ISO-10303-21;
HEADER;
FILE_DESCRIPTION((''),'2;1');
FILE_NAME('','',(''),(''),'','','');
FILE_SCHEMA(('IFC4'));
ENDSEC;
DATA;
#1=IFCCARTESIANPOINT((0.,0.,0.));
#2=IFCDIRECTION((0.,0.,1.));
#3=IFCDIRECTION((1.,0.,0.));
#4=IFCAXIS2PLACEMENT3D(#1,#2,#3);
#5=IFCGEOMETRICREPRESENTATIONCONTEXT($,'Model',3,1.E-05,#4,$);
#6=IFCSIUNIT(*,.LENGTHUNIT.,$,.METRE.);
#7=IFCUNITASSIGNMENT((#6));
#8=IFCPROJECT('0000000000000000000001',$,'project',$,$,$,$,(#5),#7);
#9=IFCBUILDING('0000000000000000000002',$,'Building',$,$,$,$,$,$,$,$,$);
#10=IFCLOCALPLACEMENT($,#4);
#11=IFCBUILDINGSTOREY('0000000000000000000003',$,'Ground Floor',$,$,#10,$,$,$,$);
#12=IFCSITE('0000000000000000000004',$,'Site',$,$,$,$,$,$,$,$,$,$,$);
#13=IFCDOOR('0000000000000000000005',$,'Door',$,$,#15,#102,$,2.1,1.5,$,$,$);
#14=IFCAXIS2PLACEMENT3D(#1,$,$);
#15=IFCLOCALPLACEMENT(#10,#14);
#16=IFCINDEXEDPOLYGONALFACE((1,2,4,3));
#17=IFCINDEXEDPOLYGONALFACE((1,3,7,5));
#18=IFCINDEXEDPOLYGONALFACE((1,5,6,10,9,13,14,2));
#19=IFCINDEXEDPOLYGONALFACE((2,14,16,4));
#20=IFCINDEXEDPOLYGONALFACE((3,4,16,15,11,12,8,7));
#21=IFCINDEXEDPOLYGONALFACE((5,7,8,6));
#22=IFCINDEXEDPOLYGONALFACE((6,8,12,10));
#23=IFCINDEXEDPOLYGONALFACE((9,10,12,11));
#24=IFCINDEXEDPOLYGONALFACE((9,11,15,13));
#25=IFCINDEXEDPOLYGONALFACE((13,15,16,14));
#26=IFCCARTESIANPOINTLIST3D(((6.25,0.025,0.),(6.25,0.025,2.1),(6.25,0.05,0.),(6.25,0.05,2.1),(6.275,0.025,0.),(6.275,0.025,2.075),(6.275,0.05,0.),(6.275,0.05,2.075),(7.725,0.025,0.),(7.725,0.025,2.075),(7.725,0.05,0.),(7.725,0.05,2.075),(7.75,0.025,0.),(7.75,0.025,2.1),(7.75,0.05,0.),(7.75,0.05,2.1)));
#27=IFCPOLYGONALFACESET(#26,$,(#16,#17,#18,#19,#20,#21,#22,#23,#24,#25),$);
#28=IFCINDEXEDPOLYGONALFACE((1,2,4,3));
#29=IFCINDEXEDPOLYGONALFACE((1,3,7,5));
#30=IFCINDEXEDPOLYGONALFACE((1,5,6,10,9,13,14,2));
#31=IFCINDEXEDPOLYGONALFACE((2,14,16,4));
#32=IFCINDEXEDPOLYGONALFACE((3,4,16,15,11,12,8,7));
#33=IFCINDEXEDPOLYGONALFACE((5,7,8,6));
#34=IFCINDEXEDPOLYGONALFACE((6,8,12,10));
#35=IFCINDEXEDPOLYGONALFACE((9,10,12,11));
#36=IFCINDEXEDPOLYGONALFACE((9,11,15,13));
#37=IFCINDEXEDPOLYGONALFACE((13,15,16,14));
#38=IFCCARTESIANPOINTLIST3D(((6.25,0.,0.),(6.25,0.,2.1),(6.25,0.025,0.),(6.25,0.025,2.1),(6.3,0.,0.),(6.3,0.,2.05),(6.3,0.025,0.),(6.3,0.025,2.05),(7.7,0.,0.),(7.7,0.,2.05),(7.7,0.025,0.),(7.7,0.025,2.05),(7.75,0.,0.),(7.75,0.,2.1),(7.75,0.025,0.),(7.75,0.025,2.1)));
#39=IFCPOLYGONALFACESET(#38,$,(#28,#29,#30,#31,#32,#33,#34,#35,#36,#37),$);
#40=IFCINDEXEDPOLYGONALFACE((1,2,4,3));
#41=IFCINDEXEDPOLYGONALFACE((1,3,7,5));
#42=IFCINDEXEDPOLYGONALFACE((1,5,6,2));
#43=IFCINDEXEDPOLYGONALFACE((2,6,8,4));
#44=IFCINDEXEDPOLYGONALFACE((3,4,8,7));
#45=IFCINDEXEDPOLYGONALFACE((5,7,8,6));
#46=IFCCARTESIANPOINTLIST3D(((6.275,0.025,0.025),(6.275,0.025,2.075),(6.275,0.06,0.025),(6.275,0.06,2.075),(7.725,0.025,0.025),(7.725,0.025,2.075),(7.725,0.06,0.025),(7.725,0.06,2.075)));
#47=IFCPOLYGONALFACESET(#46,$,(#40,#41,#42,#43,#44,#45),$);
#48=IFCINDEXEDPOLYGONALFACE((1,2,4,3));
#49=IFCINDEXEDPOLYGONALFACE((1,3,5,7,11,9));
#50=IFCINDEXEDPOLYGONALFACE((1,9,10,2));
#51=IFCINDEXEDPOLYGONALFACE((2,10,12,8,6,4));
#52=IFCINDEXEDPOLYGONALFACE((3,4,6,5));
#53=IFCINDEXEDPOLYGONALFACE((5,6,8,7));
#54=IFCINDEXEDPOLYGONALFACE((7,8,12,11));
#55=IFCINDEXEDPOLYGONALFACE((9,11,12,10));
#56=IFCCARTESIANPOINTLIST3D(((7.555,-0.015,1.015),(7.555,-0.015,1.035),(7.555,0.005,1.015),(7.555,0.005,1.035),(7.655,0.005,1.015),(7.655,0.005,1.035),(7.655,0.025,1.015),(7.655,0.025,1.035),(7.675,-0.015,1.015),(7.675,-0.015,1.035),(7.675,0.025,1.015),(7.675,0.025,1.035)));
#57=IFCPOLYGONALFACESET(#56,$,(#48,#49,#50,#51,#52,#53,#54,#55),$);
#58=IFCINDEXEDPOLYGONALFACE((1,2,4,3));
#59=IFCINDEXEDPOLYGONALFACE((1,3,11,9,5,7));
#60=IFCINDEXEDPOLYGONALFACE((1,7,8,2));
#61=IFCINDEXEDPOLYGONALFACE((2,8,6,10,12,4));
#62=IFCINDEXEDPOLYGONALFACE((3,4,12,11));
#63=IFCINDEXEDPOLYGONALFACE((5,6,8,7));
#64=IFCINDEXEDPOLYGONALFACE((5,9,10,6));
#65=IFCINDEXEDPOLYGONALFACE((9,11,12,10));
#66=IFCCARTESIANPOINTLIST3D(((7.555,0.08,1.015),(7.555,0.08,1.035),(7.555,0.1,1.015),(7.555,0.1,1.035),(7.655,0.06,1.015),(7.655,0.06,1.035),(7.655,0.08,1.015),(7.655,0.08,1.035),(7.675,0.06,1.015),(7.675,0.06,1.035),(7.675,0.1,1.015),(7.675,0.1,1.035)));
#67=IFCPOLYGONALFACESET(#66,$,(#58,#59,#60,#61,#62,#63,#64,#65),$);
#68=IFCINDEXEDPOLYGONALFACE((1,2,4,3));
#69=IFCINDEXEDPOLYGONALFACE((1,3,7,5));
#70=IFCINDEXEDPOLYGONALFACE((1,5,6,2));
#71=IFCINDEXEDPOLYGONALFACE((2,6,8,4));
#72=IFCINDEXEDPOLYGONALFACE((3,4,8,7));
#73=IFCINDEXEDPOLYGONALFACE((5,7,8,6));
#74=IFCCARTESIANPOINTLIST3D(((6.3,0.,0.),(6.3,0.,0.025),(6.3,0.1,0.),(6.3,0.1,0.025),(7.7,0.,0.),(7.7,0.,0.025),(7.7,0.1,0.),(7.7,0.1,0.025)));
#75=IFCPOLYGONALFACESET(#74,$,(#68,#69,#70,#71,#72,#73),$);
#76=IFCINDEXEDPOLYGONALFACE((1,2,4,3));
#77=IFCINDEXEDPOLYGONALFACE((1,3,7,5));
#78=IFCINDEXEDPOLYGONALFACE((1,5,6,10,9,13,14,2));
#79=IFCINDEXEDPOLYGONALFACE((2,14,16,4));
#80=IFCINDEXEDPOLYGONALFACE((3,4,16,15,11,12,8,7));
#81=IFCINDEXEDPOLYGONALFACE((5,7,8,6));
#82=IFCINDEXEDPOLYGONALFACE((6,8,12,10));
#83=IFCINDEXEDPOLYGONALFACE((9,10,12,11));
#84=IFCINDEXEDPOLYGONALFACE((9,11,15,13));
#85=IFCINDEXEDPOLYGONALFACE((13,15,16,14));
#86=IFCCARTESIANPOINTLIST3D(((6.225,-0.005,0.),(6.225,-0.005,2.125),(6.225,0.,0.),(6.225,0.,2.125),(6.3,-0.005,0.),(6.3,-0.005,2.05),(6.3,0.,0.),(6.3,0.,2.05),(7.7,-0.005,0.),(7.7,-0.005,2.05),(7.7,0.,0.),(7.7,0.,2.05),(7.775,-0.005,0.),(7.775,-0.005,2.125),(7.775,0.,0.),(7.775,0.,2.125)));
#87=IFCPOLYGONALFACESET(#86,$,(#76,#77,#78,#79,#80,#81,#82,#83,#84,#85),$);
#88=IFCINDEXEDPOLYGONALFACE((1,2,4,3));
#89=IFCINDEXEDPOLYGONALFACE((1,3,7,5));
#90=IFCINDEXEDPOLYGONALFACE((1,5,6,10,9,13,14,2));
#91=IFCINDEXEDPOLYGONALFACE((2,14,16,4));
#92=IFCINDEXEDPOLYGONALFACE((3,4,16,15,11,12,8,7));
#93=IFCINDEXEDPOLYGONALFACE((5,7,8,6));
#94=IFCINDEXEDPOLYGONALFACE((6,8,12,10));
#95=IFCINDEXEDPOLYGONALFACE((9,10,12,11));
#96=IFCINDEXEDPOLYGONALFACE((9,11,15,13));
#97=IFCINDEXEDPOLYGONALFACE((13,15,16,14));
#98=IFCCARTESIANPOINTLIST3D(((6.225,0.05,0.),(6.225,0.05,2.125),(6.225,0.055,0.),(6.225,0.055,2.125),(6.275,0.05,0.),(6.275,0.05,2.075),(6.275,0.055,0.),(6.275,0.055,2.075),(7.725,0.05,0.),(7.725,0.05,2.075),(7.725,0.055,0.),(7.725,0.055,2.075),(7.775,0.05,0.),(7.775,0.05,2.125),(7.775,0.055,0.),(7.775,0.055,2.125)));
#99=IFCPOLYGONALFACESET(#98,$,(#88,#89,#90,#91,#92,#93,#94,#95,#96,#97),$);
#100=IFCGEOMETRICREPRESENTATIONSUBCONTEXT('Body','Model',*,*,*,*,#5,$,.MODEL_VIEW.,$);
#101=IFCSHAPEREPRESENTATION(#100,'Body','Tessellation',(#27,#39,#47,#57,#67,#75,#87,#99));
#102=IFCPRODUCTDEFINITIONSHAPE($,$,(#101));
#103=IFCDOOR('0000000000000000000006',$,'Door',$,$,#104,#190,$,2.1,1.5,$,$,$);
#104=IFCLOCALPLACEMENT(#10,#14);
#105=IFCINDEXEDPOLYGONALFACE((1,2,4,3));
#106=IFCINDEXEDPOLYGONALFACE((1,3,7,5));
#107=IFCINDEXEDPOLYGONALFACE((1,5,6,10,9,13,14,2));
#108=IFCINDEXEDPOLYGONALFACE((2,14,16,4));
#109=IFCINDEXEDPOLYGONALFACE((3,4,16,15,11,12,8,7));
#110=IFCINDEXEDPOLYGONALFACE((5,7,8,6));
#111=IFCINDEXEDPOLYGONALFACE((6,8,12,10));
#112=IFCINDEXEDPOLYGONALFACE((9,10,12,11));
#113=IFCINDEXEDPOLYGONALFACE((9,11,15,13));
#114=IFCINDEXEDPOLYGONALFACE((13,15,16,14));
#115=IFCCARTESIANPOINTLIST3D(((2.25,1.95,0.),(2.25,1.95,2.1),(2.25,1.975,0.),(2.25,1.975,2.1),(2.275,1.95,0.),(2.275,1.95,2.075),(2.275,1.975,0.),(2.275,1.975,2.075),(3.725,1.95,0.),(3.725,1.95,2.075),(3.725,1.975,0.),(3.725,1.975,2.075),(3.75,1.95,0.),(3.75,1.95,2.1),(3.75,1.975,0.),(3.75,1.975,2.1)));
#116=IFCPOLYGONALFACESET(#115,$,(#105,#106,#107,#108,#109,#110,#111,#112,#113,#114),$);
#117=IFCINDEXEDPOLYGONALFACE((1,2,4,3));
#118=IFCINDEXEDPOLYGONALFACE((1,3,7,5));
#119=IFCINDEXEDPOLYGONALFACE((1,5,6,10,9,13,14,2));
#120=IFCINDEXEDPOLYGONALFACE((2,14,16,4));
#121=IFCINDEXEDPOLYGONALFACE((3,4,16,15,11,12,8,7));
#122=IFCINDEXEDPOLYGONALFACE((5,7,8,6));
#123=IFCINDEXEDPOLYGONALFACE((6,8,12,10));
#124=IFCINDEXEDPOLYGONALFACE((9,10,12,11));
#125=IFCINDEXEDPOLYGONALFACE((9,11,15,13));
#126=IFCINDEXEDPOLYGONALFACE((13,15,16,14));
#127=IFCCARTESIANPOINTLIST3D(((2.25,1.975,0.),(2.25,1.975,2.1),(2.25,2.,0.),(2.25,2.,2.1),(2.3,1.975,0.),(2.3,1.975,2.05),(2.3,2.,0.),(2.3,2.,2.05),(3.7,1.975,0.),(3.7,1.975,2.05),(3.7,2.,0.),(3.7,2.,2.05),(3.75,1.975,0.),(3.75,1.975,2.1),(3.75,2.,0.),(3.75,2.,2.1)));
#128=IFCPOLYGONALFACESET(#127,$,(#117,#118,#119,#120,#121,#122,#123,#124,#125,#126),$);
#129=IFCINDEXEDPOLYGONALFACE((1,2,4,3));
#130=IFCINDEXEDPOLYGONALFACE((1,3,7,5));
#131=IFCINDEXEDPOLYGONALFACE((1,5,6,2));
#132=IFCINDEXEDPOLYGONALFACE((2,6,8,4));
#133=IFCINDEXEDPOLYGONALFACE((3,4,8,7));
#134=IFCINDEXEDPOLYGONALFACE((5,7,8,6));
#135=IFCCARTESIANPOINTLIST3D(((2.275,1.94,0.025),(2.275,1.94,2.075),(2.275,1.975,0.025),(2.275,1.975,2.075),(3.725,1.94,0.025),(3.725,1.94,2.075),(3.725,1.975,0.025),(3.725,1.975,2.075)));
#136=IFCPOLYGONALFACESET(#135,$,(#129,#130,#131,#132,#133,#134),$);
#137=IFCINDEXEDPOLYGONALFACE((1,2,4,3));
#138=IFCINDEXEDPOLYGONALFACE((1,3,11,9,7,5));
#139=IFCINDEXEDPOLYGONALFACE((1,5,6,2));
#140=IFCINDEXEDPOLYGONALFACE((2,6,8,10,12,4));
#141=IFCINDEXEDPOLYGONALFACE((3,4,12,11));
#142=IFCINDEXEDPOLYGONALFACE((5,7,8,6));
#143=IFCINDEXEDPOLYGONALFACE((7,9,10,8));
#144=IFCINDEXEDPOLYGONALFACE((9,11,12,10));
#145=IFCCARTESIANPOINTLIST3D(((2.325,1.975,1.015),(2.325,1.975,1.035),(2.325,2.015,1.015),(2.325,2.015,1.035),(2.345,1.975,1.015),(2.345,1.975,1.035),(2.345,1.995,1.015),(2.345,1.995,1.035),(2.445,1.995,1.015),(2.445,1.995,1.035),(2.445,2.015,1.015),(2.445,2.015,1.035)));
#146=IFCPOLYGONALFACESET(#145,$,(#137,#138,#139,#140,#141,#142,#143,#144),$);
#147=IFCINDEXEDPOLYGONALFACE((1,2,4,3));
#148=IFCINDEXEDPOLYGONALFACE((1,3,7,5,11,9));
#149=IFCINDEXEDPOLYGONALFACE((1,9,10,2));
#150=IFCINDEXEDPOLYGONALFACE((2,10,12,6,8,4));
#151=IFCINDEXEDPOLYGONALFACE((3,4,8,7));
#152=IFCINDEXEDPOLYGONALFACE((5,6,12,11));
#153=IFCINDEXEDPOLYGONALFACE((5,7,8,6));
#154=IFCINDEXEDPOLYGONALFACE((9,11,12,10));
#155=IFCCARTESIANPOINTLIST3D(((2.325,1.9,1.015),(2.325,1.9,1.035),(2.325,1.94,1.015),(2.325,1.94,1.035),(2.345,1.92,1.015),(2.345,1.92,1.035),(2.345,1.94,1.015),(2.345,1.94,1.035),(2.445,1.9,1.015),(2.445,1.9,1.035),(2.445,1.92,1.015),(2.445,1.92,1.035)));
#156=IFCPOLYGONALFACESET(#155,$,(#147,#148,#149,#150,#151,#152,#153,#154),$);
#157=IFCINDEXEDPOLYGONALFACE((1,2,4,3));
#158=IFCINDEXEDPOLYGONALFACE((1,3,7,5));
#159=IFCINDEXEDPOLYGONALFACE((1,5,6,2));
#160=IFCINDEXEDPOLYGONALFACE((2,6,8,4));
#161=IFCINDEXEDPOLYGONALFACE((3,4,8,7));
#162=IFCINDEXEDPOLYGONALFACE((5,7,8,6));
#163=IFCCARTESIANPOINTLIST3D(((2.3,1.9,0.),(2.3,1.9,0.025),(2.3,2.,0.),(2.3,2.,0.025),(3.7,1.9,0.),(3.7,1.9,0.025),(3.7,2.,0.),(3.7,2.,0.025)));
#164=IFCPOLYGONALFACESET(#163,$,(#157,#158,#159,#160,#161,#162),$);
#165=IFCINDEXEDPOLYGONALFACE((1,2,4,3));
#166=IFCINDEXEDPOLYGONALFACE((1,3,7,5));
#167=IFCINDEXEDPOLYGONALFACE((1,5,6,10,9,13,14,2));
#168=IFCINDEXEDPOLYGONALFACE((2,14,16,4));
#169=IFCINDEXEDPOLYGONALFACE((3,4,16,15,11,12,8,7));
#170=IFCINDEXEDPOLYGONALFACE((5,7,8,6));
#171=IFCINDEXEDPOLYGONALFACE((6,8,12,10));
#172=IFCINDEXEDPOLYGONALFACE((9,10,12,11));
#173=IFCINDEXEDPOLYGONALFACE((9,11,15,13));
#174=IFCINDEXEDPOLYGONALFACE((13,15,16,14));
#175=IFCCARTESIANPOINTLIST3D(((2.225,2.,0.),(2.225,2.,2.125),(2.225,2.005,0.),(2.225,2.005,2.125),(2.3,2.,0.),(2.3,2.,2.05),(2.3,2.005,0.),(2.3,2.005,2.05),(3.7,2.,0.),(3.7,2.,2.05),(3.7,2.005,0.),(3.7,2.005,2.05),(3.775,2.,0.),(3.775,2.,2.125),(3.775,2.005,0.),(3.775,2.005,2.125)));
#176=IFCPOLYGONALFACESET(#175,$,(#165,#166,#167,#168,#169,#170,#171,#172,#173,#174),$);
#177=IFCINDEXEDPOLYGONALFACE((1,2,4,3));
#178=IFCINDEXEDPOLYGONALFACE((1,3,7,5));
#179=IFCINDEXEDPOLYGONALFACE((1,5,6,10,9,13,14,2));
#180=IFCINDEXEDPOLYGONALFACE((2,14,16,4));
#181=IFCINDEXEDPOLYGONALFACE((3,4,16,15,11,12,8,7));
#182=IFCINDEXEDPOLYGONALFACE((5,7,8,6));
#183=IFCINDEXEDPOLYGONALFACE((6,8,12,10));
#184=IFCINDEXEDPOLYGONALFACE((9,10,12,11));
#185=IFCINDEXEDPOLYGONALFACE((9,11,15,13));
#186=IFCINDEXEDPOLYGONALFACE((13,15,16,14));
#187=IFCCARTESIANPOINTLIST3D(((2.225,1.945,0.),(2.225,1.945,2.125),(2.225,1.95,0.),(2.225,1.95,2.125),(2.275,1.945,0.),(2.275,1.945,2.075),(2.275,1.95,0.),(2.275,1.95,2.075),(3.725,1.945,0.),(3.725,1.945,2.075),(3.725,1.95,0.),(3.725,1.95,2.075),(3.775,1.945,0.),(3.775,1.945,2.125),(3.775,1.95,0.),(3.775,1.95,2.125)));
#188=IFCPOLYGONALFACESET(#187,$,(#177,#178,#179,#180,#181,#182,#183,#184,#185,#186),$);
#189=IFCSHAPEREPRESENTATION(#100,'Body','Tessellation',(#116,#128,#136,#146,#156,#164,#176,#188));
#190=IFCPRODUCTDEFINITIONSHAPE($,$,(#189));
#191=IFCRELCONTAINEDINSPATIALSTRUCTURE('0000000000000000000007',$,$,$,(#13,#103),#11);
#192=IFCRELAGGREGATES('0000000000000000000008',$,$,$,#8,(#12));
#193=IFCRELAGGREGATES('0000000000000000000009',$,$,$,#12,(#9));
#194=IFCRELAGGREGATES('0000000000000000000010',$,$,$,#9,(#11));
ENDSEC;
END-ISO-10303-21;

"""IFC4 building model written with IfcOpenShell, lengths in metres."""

from ifc_helpers import new_model, si_unit, frame, origin_with_axes, place, context, subcontext, project, spatial, line, indexed_curve, outline, extrude, element, save


model = new_model("IFC4")

# Units and contexts
model_context = context("Model", 3, precision=1e-05, world=origin_with_axes())
body_context = subcontext(model_context, "Body", "Model", "MODEL_VIEW")
ifc_project = project(units=[si_unit("LENGTHUNIT", "METRE")], contexts=[model_context])

# Site, building, storey
site = spatial("IfcSite", under=ifc_project, Name="Site")
building = spatial("IfcBuilding", under=site, Name="Building")
storey_placement = place(None, origin_with_axes())
storey = spatial("IfcBuildingStorey", under=building, at=storey_placement, Name="Ground Floor")

# Doors
door_1_placement = place(storey_placement, frame((6.25, 0.0, 0.0), z_axis=(0.0, 0.0, 1.0), x_axis=(1.0, 0.0, 0.0)))
element("IfcDoor", 1, at=door_1_placement, inside=storey, Name="Door", OverallHeight=2.1, OverallWidth=1.5, context=body_context, shape_type="SweptSolid", body=[
    extrude(outline(indexed_curve([(0.0, 0.0), (0.0, 2.1), (1.5, 2.1), (1.5, 0.0), (1.475, 0.0), (1.475, 2.075), (0.025, 2.075), (0.025, 0.0)], segments=[line(1, 2, 3, 4, 5, 6, 7, 8, 1)])), frame((0.0, 0.025, 0.0), z_axis=(0.0, -1.0, 0.0), x_axis=(1.0, 0.0, 0.0)), (0.0, 0.0, -1.0), 0.025),
    extrude(outline(indexed_curve([(0.0, 0.0), (0.0, 2.1), (1.5, 2.1), (1.5, 0.0), (1.45, 0.0), (1.45, 2.05), (0.05, 2.05), (0.05, 0.0)], segments=[line(1, 2, 3, 4, 5, 6, 7, 8, 1)])), frame((0.0, 0.0, 0.0), z_axis=(0.0, -1.0, 0.0), x_axis=(1.0, 0.0, 0.0)), (0.0, 0.0, -1.0), 0.025),
    extrude(outline(indexed_curve([(0.0, 0.0), (1.45, 0.0), (1.45, 0.035), (0.0, 0.035)], segments=[line(1, 2, 3, 4, 1)])), frame((0.025, 0.025, 0.025), z_axis=(0.0, 0.0, 1.0), x_axis=(1.0, 0.0, 0.0)), (0.0, 0.0, 1.0), 2.05),
    extrude(outline(indexed_curve([(0.0, 0.0), (0.0, -0.04), (-0.12, -0.04), (-0.12, -0.02), (-0.02, -0.02), (-0.02, 0.0)], segments=[line(1, 2, 3, 4, 5, 6, 1)])), frame((1.425, 0.025, 1.015), z_axis=(0.0, 0.0, 1.0), x_axis=(1.0, 0.0, 0.0)), (0.0, 0.0, 1.0), 0.02),
    extrude(outline(indexed_curve([(0.0, 0.0), (0.0, 0.04), (-0.12, 0.04), (-0.12, 0.02), (-0.02, 0.02), (-0.02, 0.0)], segments=[line(1, 2, 3, 4, 5, 6, 1)])), frame((1.425, 0.06, 1.015), z_axis=(0.0, 0.0, 1.0), x_axis=(1.0, 0.0, 0.0)), (0.0, 0.0, 1.0), 0.02),
    extrude(outline(indexed_curve([(0.0, 0.0), (1.4, 0.0), (1.4, 0.1), (0.0, 0.1)], segments=[line(1, 2, 3, 4, 1)])), frame((0.05, 0.0, 0.0), z_axis=(0.0, 0.0, 1.0), x_axis=(1.0, 0.0, 0.0)), (0.0, 0.0, 1.0), 0.025),
    extrude(outline(indexed_curve([(0.0, 0.0), (0.0, 2.125), (1.55, 2.125), (1.55, 0.0), (1.475, 0.0), (1.475, 2.05), (0.075, 2.05), (0.075, 0.0)], segments=[line(1, 2, 3, 4, 5, 6, 7, 8, 1)])), frame((-0.025, -0.005, 0.0), z_axis=(0.0, -1.0, 0.0), x_axis=(1.0, 0.0, 0.0)), (0.0, 0.0, -1.0), 0.005),
    extrude(outline(indexed_curve([(0.0, 0.0), (0.0, 2.125), (1.55, 2.125), (1.55, 0.0), (1.5, 0.0), (1.5, 2.075), (0.05, 2.075), (0.05, 0.0)], segments=[line(1, 2, 3, 4, 5, 6, 7, 8, 1)])), frame((-0.025, 0.05, 0.0), z_axis=(0.0, -1.0, 0.0), x_axis=(1.0, 0.0, 0.0)), (0.0, 0.0, -1.0), 0.005),
])
door_2_placement = place(storey_placement, frame((3.75, 2.0, 0.0), z_axis=(0.0, 0.0, 1.0), x_axis=(-1.0, 0.0, 0.0)))
element("IfcDoor", 2, at=door_2_placement, inside=storey, Name="Door", OverallHeight=2.1, OverallWidth=1.5, context=body_context, shape_type="SweptSolid", body=[
    extrude(outline(indexed_curve([(0.0, 0.0), (0.0, 2.1), (1.5, 2.1), (1.5, 0.0), (1.475, 0.0), (1.475, 2.075), (0.025, 2.075), (0.025, 0.0)], segments=[line(1, 2, 3, 4, 5, 6, 7, 8, 1)])), frame((0.0, 0.025, 0.0), z_axis=(0.0, -1.0, 0.0), x_axis=(1.0, 0.0, 0.0)), (0.0, 0.0, -1.0), 0.025),
    extrude(outline(indexed_curve([(0.0, 0.0), (0.0, 2.1), (1.5, 2.1), (1.5, 0.0), (1.45, 0.0), (1.45, 2.05), (0.05, 2.05), (0.05, 0.0)], segments=[line(1, 2, 3, 4, 5, 6, 7, 8, 1)])), frame((0.0, 0.0, 0.0), z_axis=(0.0, -1.0, 0.0), x_axis=(1.0, 0.0, 0.0)), (0.0, 0.0, -1.0), 0.025),
    extrude(outline(indexed_curve([(0.0, 0.0), (1.45, 0.0), (1.45, 0.035), (0.0, 0.035)], segments=[line(1, 2, 3, 4, 1)])), frame((0.025, 0.025, 0.025), z_axis=(0.0, 0.0, 1.0), x_axis=(1.0, 0.0, 0.0)), (0.0, 0.0, 1.0), 2.05),
    extrude(outline(indexed_curve([(0.0, 0.0), (0.0, -0.04), (-0.12, -0.04), (-0.12, -0.02), (-0.02, -0.02), (-0.02, 0.0)], segments=[line(1, 2, 3, 4, 5, 6, 1)])), frame((1.425, 0.025, 1.015), z_axis=(0.0, 0.0, 1.0), x_axis=(1.0, 0.0, 0.0)), (0.0, 0.0, 1.0), 0.02),
    extrude(outline(indexed_curve([(0.0, 0.0), (0.0, 0.04), (-0.12, 0.04), (-0.12, 0.02), (-0.02, 0.02), (-0.02, 0.0)], segments=[line(1, 2, 3, 4, 5, 6, 1)])), frame((1.425, 0.06, 1.015), z_axis=(0.0, 0.0, 1.0), x_axis=(1.0, 0.0, 0.0)), (0.0, 0.0, 1.0), 0.02),
    extrude(outline(indexed_curve([(0.0, 0.0), (1.4, 0.0), (1.4, 0.1), (0.0, 0.1)], segments=[line(1, 2, 3, 4, 1)])), frame((0.05, 0.0, 0.0), z_axis=(0.0, 0.0, 1.0), x_axis=(1.0, 0.0, 0.0)), (0.0, 0.0, 1.0), 0.025),
    extrude(outline(indexed_curve([(0.0, 0.0), (0.0, 2.125), (1.55, 2.125), (1.55, 0.0), (1.475, 0.0), (1.475, 2.05), (0.075, 2.05), (0.075, 0.0)], segments=[line(1, 2, 3, 4, 5, 6, 7, 8, 1)])), frame((-0.025, -0.005, 0.0), z_axis=(0.0, -1.0, 0.0), x_axis=(1.0, 0.0, 0.0)), (0.0, 0.0, -1.0), 0.005),
    extrude(outline(indexed_curve([(0.0, 0.0), (0.0, 2.125), (1.55, 2.125), (1.55, 0.0), (1.5, 0.0), (1.5, 2.075), (0.05, 2.075), (0.05, 0.0)], segments=[line(1, 2, 3, 4, 5, 6, 7, 8, 1)])), frame((-0.025, 0.05, 0.0), z_axis=(0.0, -1.0, 0.0), x_axis=(1.0, 0.0, 0.0)), (0.0, 0.0, -1.0), 0.005),
])

save(model, "model.ifc")
